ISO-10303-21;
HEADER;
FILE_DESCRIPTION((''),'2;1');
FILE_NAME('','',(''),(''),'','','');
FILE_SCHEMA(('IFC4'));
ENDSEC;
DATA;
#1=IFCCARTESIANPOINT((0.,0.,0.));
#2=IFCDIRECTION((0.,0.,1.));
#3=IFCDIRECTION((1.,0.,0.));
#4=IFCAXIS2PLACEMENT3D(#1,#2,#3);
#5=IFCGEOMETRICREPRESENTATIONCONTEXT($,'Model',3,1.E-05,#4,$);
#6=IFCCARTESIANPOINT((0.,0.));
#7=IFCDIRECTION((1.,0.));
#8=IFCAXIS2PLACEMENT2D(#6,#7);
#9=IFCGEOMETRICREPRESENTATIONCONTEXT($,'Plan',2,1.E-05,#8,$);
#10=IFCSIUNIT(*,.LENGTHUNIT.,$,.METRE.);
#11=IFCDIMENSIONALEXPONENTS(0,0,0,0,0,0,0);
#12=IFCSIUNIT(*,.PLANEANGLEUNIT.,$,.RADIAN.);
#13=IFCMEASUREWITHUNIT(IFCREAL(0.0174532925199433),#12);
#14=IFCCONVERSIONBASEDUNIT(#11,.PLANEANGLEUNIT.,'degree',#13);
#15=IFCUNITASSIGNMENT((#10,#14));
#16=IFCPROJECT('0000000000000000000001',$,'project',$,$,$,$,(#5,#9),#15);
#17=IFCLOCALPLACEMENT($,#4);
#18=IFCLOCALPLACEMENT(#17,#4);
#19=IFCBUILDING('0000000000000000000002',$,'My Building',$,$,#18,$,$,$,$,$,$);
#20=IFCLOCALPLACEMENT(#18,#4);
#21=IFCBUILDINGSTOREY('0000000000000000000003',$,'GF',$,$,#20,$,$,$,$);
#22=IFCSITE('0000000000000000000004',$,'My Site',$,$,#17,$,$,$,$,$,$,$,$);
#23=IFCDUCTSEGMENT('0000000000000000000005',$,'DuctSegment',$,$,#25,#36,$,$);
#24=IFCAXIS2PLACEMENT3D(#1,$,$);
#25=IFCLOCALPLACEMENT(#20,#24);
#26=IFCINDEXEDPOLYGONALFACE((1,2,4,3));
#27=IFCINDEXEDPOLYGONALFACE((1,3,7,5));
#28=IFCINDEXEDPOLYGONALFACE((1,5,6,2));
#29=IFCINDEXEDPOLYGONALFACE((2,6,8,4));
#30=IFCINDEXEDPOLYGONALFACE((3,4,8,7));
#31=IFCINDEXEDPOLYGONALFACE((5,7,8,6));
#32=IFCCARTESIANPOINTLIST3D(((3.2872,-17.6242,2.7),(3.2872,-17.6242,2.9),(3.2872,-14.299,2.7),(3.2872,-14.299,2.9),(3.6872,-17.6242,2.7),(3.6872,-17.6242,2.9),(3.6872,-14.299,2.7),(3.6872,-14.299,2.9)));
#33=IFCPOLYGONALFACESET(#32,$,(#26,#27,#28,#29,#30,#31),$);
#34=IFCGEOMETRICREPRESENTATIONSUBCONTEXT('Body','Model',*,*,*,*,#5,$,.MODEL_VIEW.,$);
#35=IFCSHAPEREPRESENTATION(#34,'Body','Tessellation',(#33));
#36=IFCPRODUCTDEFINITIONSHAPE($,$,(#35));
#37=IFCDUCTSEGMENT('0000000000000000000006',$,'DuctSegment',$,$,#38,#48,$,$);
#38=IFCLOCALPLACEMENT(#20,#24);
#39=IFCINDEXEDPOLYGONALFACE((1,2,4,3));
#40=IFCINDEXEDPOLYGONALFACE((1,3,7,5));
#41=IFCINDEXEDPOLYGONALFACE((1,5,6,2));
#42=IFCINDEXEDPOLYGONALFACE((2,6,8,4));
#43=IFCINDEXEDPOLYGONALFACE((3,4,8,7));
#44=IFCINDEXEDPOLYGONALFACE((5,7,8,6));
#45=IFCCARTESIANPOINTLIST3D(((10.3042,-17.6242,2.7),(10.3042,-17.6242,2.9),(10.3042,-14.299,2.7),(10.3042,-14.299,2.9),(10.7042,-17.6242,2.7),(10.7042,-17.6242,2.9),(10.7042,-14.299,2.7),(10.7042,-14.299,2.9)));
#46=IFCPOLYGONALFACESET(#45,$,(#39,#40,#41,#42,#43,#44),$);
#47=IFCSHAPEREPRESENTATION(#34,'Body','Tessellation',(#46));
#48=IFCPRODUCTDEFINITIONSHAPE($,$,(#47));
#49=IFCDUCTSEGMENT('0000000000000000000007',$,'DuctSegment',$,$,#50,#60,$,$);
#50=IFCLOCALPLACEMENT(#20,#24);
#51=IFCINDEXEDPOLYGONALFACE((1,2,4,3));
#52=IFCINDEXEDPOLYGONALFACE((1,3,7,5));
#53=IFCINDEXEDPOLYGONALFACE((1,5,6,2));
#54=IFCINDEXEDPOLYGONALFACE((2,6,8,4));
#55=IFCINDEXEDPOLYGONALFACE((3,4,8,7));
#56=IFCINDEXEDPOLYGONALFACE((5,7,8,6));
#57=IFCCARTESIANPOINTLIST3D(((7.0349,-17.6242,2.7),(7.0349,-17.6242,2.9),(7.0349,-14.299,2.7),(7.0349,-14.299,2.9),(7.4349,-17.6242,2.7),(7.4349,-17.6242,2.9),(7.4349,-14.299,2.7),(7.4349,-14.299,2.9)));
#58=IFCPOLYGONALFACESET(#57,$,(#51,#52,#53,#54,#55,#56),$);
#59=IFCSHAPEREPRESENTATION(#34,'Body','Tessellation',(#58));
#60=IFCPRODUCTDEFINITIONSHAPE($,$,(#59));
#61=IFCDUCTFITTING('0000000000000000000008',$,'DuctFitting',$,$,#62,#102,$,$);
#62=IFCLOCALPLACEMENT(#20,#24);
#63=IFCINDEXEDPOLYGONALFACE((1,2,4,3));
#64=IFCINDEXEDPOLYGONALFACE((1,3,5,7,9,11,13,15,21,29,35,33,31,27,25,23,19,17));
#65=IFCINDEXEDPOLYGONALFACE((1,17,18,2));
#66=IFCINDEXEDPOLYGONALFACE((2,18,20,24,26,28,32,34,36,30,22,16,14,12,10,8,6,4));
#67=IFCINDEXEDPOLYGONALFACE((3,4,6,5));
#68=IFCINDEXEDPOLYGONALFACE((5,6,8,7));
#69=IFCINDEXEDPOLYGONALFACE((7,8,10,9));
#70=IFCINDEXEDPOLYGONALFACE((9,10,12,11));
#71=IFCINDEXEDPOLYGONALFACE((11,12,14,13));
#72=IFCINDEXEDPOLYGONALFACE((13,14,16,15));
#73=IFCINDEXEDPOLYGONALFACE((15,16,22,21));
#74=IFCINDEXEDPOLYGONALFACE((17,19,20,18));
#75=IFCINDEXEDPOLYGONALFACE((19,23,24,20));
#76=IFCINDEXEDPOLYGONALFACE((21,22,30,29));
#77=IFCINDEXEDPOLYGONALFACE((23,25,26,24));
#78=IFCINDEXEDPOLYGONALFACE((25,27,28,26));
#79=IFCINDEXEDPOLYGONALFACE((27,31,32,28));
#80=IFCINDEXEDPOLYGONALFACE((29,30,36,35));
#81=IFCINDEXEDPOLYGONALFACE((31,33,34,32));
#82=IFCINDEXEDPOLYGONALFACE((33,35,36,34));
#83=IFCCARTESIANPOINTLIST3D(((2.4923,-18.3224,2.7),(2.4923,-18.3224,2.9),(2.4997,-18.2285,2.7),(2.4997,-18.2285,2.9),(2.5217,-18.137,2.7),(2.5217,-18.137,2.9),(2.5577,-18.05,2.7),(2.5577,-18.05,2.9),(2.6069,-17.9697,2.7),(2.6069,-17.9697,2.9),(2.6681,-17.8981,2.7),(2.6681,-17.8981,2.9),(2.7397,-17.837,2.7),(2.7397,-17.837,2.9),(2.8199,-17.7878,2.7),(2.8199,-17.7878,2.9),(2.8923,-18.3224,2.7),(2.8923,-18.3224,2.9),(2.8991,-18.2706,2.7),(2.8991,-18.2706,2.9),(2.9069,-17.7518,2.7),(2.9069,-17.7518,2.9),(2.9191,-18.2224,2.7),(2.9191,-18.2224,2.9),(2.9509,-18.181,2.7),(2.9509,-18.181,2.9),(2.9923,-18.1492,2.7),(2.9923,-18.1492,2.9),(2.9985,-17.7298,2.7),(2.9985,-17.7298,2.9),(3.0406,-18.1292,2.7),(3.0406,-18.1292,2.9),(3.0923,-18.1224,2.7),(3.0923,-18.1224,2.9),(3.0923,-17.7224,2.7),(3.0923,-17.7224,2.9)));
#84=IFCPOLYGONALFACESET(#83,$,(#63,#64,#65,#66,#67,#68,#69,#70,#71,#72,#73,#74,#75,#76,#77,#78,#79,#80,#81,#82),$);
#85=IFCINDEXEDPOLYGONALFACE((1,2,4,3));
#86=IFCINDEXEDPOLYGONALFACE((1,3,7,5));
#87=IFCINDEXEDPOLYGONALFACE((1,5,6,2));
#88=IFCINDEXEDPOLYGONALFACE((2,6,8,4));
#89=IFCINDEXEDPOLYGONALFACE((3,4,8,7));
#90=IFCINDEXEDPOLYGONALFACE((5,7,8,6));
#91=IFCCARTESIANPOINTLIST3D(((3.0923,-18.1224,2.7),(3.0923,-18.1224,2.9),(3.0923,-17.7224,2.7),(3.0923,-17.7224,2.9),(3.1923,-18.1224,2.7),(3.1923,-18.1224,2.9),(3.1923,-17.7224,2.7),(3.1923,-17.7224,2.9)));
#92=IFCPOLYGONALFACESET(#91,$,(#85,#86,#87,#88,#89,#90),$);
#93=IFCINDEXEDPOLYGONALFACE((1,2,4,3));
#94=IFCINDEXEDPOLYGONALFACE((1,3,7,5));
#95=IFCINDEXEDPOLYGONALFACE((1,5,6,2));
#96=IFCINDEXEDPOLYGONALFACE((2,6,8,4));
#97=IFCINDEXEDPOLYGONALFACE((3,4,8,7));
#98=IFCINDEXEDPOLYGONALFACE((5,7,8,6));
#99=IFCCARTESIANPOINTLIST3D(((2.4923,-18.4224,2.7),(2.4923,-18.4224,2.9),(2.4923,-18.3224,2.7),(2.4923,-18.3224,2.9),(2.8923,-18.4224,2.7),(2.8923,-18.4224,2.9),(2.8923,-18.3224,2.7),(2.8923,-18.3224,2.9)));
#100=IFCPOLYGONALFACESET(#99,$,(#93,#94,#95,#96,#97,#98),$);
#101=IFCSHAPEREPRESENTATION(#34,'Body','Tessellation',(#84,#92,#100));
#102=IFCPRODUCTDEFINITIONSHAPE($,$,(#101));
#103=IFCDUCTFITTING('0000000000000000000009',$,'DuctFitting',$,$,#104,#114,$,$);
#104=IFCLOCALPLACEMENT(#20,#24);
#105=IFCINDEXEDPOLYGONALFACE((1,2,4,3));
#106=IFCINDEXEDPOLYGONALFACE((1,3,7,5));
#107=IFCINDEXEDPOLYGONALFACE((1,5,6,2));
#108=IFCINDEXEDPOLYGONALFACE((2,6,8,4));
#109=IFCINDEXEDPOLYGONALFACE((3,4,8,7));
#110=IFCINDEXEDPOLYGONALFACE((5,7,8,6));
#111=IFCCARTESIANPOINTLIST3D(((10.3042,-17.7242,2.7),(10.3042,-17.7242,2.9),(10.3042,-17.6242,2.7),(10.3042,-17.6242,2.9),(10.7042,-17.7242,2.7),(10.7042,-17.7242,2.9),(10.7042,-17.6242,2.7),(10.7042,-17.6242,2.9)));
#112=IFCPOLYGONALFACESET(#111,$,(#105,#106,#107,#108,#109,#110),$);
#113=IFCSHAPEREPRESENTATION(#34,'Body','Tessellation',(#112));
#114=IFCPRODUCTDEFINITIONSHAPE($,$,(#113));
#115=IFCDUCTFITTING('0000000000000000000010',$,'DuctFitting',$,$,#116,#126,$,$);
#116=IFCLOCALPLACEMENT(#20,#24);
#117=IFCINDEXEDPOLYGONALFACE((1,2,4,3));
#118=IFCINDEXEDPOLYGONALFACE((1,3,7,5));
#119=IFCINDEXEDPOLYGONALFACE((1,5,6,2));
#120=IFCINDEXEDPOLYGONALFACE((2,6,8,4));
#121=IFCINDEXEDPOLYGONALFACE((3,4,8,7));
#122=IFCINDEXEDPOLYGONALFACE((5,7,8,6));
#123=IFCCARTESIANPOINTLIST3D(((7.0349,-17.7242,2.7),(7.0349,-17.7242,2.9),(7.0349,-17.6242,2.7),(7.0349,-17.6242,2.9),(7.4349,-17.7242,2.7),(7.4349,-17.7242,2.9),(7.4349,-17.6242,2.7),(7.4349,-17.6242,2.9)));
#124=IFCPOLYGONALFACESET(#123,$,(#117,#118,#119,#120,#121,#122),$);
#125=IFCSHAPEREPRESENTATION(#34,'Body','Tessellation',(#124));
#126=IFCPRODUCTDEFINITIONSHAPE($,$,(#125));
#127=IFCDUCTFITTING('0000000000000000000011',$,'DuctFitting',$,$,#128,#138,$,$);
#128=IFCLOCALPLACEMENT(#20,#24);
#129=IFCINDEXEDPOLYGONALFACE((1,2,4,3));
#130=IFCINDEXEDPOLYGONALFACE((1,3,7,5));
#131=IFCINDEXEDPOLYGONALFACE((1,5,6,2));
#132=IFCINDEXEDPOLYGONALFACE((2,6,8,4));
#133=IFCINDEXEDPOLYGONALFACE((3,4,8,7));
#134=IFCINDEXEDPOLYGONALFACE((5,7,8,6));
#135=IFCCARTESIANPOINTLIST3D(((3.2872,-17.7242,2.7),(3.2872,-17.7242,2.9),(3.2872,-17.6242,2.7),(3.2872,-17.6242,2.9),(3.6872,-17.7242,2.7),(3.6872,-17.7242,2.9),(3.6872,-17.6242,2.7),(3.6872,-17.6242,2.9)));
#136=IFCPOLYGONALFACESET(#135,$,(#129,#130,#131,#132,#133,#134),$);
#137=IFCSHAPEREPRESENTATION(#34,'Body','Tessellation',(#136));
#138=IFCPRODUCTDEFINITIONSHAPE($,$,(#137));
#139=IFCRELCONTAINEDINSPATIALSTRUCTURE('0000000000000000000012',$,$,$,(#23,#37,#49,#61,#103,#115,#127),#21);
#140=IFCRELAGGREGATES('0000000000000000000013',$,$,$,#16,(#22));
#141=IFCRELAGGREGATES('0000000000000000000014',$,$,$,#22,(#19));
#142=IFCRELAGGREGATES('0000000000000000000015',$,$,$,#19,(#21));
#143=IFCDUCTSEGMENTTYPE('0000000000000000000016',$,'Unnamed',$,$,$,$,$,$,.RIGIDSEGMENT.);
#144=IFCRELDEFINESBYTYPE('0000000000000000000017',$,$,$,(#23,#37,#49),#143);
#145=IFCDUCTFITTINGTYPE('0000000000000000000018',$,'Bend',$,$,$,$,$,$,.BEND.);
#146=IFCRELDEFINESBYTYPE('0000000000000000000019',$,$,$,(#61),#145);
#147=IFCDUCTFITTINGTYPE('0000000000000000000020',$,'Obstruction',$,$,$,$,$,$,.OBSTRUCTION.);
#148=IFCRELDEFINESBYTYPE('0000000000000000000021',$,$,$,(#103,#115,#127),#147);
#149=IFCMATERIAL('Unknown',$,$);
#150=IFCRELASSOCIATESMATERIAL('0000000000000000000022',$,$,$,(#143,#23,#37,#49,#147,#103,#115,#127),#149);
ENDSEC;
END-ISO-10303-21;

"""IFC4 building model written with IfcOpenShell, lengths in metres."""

from ifc_helpers import new_model, entity, si_unit, converted_unit, frame, origin_with_axes, origin_2d_with_axis, place, context, subcontext, project, spatial, line, arc, indexed_curve, rectangle, outline, extrude, source, transform, mapped, material, material_profile, profile_set, profile_usage, type_object, type_shapes, element, save


model = new_model("IFC4")

# Units and contexts
model_context = context("Model", 3, precision=1e-05, world=origin_with_axes())
plan_context = context("Plan", 2, precision=1e-05, world=origin_2d_with_axis())
body_context_1 = subcontext(model_context, "Body", "Model", "MODEL_VIEW")
ifc_project = project(units=[si_unit("LENGTHUNIT", "METRE"), converted_unit("PLANEANGLEUNIT", "degree", entity("IfcReal", 0.0174532925199433), si_unit("PLANEANGLEUNIT", "RADIAN"), dimensions=[0, 0, 0, 0, 0, 0, 0])], contexts=[model_context, plan_context])

# Site, building, storey
site_placement = place(None, origin_with_axes())
site = spatial("IfcSite", under=ifc_project, at=site_placement, Name="My Site")
building_placement = place(site_placement, origin_with_axes())
building = spatial("IfcBuilding", under=site, at=building_placement, Name="My Building")
storey_placement = place(building_placement, origin_with_axes())
storey = spatial("IfcBuildingStorey", under=building, at=storey_placement, Name="GF")

# Shared definitions
ifc_material = material(Name="Unknown")

# Duct segments
ifc_material_profile_1 = material_profile(ifc_material, rectangle(XDim=0.4, YDim=0.2))
ifc_profile_set_1 = profile_set([ifc_material_profile_1])
ifc_profile_usage_1 = profile_usage(ifc_profile_set_1, cardinal=5)
duct_segment_type = type_object("IfcDuctSegmentType", Name="Unnamed", PredefinedType="RIGIDSEGMENT", material=ifc_profile_set_1)
duct_segment_1_placement = place(storey_placement, frame((3.4872, -17.6242, 2.8), z_axis=(0.0, 1.0, 0.0), x_axis=(-1.0, 0.0, 0.0)))
element("IfcDuctSegment", 1, at=duct_segment_1_placement, inside=storey, type_object=duct_segment_type, material=ifc_profile_usage_1, Name="DuctSegment", context=body_context_1, shape_type="SweptSolid", body=[
    extrude(rectangle(XDim=0.4, YDim=0.2), origin_with_axes(), (0.0, 0.0, 1.0), 3.3252),
])
ifc_profile_usage_2 = profile_usage(ifc_profile_set_1, cardinal=5)
duct_segment_2_placement = place(storey_placement, frame((10.5042, -17.6242, 2.8), z_axis=(0.0, 1.0, 0.0), x_axis=(-1.0, 0.0, 0.0)))
element("IfcDuctSegment", 2, at=duct_segment_2_placement, inside=storey, type_object=duct_segment_type, material=ifc_profile_usage_2, Name="DuctSegment", context=body_context_1, shape_type="SweptSolid", body=[
    extrude(rectangle(XDim=0.4, YDim=0.2), origin_with_axes(), (0.0, 0.0, 1.0), 3.3252),
])
ifc_profile_usage_3 = profile_usage(ifc_profile_set_1, cardinal=5)
duct_segment_3_placement = place(storey_placement, frame((7.2349, -17.6242, 2.8), z_axis=(0.0, 1.0, 0.0), x_axis=(-1.0, 0.0, 0.0)))
element("IfcDuctSegment", 3, at=duct_segment_3_placement, inside=storey, type_object=duct_segment_type, material=ifc_profile_usage_3, Name="DuctSegment", context=body_context_1, shape_type="SweptSolid", body=[
    extrude(rectangle(XDim=0.4, YDim=0.2), origin_with_axes(), (0.0, 0.0, 1.0), 3.3252),
])

# Duct fittings
duct_fitting_type_1 = type_object("IfcDuctFittingType", Name="Bend", PredefinedType="BEND")
shared_shape_1 = source(origin_with_axes(), body_context_1, "Body", "SweptSolid", [
    extrude(outline(indexed_curve([(0.2, 0.0), (0.2586, 0.1414), (0.4, 0.2), (0.4, 0.6), (-0.0243, 0.4243), (-0.2, 0.0)], segments=[arc(1, 2, 3), line(3, 4), arc(4, 5, 6), line(6, 1)])), frame((0.0, -0.1, 0.1), z_axis=(0.0, -1.0, 0.0), x_axis=(1.0, 0.0, 0.0)), (0.0, 0.0, -1.0), 0.2),
    extrude(rectangle(XDim=0.4, YDim=0.2), origin_with_axes(), (0.0, 0.0, 1.0), 0.1),
    extrude(rectangle(XDim=0.4, YDim=0.2), frame((0.4, 0.0, 0.5), z_axis=(1.0, 0.0, 0.0), x_axis=(0.0, 0.0, 1.0)), (0.0, 0.0, 1.0), 0.1),
])
type_shapes(duct_fitting_type_1, [shared_shape_1])
duct_fitting_1_placement = place(storey_placement, frame((3.1923, -17.9224, 2.8), z_axis=(-1.0, 0.0, 0.0), x_axis=(0.0, -1.0, 0.0)))
element("IfcDuctFitting", 4, at=duct_fitting_1_placement, inside=storey, type_object=duct_fitting_type_1, Name="DuctFitting", context=body_context_1, shape_type="MappedRepresentation", body=[
    mapped(shared_shape_1, transform((0.0, 0.0, 0.0), x_axis=(1.0, 0.0, 0.0), y_axis=(0.0, 1.0, 0.0), z_axis=(0.0, 0.0, 1.0), scale=1.0)),
])
ifc_material_profile_2 = material_profile(ifc_material, rectangle(XDim=0.4, YDim=0.2))
ifc_profile_set_2 = profile_set([ifc_material_profile_2])
ifc_profile_usage_4 = profile_usage(ifc_profile_set_2, cardinal=5)
duct_fitting_type_2 = type_object("IfcDuctFittingType", Name="Obstruction", PredefinedType="OBSTRUCTION", material=ifc_profile_set_2)
duct_fitting_2_placement = place(storey_placement, frame((10.5042, -17.7242, 2.8), z_axis=(0.0, 1.0, 0.0), x_axis=(-1.0, 0.0, 0.0)))
element("IfcDuctFitting", 5, at=duct_fitting_2_placement, inside=storey, type_object=duct_fitting_type_2, material=ifc_profile_usage_4, Name="DuctFitting", context=body_context_1, shape_type="SweptSolid", body=[
    extrude(rectangle(XDim=0.4, YDim=0.2), origin_with_axes(), (0.0, 0.0, 1.0), 0.1),
])
ifc_profile_usage_5 = profile_usage(ifc_profile_set_2, cardinal=5)
duct_fitting_3_placement = place(storey_placement, frame((7.2349, -17.7242, 2.8), z_axis=(0.0, 1.0, 0.0), x_axis=(-1.0, 0.0, 0.0)))
element("IfcDuctFitting", 6, at=duct_fitting_3_placement, inside=storey, type_object=duct_fitting_type_2, material=ifc_profile_usage_5, Name="DuctFitting", context=body_context_1, shape_type="SweptSolid", body=[
    extrude(rectangle(XDim=0.4, YDim=0.2), origin_with_axes(), (0.0, 0.0, 1.0), 0.1),
])
ifc_profile_usage_6 = profile_usage(ifc_profile_set_2, cardinal=5)
duct_fitting_4_placement = place(storey_placement, frame((3.4872, -17.7242, 2.8), z_axis=(0.0, 1.0, 0.0), x_axis=(-1.0, 0.0, 0.0)))
element("IfcDuctFitting", 7, at=duct_fitting_4_placement, inside=storey, type_object=duct_fitting_type_2, material=ifc_profile_usage_6, Name="DuctFitting", context=body_context_1, shape_type="SweptSolid", body=[
    extrude(rectangle(XDim=0.4, YDim=0.2), origin_with_axes(), (0.0, 0.0, 1.0), 0.1),
])

save(model, "model.ifc")
